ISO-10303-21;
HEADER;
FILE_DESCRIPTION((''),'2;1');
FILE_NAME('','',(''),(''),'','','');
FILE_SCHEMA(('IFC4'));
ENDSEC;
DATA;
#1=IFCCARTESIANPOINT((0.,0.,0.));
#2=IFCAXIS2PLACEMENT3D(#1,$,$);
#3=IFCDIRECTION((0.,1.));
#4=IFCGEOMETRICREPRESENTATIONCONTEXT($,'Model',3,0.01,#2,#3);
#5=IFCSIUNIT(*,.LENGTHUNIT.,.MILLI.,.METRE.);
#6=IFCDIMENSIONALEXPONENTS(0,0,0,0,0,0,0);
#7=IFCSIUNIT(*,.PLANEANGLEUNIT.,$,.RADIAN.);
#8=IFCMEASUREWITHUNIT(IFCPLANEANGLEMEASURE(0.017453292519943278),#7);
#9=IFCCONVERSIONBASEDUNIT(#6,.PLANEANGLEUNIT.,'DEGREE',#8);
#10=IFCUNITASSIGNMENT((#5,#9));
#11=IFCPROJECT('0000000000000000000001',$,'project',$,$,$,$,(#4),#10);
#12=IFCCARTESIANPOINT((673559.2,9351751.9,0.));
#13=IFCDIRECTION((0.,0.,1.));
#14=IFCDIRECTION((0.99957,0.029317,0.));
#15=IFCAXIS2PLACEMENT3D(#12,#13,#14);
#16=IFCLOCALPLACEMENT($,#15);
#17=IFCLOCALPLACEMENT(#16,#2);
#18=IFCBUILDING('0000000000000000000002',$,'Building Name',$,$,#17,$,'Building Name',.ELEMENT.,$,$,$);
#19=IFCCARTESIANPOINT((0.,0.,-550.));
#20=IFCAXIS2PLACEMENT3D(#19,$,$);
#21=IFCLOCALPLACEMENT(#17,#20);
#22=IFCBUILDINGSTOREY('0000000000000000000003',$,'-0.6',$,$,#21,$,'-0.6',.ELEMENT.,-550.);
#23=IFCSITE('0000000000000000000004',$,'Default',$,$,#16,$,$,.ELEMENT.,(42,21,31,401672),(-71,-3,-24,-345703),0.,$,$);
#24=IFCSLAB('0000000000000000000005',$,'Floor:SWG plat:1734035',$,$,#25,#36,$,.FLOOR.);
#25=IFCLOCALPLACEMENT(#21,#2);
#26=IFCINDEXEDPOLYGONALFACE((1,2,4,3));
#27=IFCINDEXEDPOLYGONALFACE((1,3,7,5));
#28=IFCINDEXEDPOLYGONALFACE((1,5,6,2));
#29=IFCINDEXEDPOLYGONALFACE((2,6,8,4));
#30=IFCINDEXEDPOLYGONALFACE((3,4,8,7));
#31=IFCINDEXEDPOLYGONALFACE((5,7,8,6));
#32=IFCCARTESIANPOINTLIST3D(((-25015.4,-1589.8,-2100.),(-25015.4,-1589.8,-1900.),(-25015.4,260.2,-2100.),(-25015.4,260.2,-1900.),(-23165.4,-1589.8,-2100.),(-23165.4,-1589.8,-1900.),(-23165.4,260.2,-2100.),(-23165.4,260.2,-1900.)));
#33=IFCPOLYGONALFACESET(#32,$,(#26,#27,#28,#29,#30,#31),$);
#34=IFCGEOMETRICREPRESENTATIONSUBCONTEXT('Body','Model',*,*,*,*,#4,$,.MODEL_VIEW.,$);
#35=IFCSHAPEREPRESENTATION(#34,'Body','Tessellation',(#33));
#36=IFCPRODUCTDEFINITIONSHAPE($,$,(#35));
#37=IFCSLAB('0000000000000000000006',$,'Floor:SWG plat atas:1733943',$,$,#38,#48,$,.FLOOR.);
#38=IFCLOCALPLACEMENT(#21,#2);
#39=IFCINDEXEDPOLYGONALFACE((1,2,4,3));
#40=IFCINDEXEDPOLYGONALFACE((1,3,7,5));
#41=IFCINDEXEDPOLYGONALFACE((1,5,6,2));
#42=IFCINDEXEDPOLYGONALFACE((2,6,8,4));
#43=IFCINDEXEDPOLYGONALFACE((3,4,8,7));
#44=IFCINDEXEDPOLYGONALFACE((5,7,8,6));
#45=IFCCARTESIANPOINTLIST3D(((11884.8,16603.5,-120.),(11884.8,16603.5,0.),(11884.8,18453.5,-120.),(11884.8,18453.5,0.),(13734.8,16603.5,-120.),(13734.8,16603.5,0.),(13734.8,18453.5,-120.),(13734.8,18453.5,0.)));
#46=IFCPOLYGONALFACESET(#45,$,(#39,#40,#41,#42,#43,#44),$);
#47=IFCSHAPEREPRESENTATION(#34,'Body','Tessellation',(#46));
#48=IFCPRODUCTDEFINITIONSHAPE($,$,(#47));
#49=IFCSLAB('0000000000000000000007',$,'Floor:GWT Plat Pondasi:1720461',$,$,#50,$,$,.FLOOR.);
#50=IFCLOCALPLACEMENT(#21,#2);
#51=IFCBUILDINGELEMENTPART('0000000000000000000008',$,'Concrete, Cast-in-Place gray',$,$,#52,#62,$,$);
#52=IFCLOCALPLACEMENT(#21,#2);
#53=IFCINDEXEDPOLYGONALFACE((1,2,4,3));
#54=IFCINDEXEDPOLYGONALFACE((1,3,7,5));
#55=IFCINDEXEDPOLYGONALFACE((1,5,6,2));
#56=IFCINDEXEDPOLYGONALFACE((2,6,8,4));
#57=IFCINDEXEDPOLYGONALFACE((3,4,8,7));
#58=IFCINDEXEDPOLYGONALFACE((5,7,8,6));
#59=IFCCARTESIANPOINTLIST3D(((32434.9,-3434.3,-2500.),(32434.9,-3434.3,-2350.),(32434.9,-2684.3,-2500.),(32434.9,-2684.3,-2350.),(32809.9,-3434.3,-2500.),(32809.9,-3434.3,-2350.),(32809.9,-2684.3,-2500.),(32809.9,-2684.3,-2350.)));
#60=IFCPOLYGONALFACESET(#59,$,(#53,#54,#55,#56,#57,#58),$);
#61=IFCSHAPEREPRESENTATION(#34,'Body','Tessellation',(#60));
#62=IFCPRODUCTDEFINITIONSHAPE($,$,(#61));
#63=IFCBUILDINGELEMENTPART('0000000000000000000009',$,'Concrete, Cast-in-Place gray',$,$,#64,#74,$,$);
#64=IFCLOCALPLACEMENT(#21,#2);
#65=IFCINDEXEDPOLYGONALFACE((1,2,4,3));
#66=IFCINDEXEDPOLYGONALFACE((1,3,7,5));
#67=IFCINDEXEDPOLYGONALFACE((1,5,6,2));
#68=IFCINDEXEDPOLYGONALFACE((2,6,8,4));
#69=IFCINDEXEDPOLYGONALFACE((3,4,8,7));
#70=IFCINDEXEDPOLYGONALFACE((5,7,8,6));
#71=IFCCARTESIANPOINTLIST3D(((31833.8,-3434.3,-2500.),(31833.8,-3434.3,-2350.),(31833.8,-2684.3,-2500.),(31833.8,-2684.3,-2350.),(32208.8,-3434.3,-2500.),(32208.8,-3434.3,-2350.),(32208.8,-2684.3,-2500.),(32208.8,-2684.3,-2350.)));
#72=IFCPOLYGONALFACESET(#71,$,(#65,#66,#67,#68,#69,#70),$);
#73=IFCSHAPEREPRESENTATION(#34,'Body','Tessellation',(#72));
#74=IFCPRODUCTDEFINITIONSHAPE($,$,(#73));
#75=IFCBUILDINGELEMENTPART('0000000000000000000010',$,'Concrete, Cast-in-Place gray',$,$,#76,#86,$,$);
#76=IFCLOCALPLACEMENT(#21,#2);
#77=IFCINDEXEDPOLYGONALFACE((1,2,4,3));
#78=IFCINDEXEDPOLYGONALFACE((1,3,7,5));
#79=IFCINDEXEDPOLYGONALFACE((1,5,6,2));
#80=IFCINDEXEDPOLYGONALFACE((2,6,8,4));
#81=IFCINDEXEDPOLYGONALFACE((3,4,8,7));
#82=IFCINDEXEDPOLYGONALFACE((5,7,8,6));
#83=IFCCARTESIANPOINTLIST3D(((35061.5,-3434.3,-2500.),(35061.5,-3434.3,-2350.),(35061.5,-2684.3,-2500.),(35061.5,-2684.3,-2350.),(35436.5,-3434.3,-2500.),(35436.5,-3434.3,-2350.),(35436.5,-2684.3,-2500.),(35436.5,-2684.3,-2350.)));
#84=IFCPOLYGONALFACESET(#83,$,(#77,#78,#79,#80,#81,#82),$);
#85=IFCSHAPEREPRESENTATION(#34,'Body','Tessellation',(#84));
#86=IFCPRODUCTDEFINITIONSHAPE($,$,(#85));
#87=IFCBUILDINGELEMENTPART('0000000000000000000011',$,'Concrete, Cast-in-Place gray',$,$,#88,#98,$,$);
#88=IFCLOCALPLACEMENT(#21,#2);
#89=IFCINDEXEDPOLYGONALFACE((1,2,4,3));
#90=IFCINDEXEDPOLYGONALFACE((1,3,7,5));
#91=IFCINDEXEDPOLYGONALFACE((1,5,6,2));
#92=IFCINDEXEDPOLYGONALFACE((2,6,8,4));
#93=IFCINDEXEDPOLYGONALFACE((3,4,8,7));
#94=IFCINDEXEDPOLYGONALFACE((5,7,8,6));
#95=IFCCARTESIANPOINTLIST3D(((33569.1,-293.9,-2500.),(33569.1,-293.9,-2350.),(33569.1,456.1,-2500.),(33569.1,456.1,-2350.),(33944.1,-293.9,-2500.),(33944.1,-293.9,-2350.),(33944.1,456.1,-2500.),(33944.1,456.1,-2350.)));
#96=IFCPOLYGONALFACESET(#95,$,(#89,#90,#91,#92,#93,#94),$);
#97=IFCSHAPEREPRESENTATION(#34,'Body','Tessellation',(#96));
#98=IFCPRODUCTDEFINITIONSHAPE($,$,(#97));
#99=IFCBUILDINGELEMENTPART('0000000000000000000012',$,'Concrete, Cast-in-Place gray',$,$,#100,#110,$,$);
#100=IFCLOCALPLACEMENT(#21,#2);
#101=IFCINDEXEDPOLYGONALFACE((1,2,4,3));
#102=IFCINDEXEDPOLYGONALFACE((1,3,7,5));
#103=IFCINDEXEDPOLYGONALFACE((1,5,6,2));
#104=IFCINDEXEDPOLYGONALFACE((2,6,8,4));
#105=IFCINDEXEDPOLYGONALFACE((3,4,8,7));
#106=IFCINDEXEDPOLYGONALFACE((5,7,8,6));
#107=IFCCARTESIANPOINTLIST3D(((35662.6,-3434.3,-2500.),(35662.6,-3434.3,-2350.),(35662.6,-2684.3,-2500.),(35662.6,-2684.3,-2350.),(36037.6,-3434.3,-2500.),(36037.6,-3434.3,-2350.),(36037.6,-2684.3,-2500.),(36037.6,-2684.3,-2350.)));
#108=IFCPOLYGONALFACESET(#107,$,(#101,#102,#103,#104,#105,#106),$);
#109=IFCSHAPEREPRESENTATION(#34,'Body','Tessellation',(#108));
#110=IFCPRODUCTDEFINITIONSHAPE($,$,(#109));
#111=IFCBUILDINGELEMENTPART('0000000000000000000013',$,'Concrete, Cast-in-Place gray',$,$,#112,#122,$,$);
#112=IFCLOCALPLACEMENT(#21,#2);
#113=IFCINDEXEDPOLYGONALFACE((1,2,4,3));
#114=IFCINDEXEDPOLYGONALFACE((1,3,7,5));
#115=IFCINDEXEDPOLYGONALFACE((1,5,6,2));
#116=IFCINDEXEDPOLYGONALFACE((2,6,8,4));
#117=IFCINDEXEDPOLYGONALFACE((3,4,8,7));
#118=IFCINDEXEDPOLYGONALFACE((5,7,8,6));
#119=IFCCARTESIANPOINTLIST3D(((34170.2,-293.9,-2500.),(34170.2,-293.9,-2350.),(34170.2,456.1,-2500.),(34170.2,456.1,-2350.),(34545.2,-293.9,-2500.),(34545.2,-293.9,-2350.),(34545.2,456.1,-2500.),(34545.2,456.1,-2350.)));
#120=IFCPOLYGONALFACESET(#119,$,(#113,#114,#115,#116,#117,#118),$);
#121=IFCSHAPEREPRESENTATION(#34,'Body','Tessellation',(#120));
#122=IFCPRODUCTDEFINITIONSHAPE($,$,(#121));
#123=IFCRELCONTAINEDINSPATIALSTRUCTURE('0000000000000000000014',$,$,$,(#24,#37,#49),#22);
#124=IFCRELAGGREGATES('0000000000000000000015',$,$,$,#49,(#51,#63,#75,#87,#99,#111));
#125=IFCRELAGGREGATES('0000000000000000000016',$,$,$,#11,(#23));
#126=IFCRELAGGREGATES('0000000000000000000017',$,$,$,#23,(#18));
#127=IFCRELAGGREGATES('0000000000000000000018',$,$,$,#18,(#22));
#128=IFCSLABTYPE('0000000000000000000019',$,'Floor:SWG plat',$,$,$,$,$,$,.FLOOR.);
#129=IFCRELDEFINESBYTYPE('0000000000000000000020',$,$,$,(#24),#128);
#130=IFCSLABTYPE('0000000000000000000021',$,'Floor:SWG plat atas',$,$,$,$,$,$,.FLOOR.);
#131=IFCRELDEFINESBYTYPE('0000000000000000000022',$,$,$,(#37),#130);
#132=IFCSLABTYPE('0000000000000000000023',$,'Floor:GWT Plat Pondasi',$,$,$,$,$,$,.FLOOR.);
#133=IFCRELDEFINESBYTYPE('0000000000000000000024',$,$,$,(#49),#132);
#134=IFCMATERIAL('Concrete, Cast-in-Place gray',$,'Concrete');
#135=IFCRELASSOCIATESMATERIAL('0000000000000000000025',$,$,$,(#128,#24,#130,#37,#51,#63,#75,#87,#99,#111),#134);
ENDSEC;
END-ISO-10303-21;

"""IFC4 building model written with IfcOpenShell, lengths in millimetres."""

from ifc_helpers import new_model, entity, si_unit, converted_unit, direction, frame, origin, place, context, subcontext, project, spatial, indexed_curve, outline, extrude, material, type_object, element, aggregate, save


model = new_model("IFC4")

# Units and contexts
model_context = context("Model", 3, precision=0.01, world=origin(), true_north=direction((0.0, 1.0)))
body_context = subcontext(model_context, "Body", "Model", "MODEL_VIEW")
ifc_project = project(units=[si_unit("LENGTHUNIT", "METRE", prefix="MILLI"), converted_unit("PLANEANGLEUNIT", "DEGREE", entity("IfcPlaneAngleMeasure", 0.017453292519943278), si_unit("PLANEANGLEUNIT", "RADIAN"), dimensions=[0, 0, 0, 0, 0, 0, 0])], contexts=[model_context])

# Site, building, storey
site_placement = place(None, frame((673559.2, 9351751.9, 0.0), z_axis=(0.0, 0.0, 1.0), x_axis=(0.99957, 0.029317, 0.0)))
site = spatial("IfcSite", under=ifc_project, at=site_placement, Name="Default", CompositionType="ELEMENT", RefLatitude=(42, 21, 31, 401672), RefLongitude=(-71, -3, -24, -345703), RefElevation=0.0)
building_placement = place(site_placement, origin())
building = spatial("IfcBuilding", under=site, at=building_placement, Name="Building Name", LongName="Building Name", CompositionType="ELEMENT")
storey_placement = place(building_placement, frame((0.0, 0.0, -550.0)))
storey = spatial("IfcBuildingStorey", under=building, at=storey_placement, Name="-0.6", LongName="-0.6", CompositionType="ELEMENT", Elevation=-550.0)

# Shared definitions
ifc_material = material(Name="Concrete, Cast-in-Place gray", Category="Concrete")

# Slabs
slab_type_1 = type_object("IfcSlabType", Name="Floor:SWG plat", PredefinedType="FLOOR", material=ifc_material)
slab_1_placement = place(storey_placement, origin())
element("IfcSlab", 1, at=slab_1_placement, inside=storey, type_object=slab_type_1, material=ifc_material, Name="Floor:SWG plat:1734035", PredefinedType="FLOOR", context=body_context, shape_type="SweptSolid", body=[
    extrude(outline(indexed_curve([(-925.0, -925.0), (925.0, -925.0), (925.0, 925.0), (-925.0, 925.0), (-925.0, -925.0)], self_intersect=False)), frame((-24090.4, -664.8, -1900.0), z_axis=(0.0, 0.0, -1.0), x_axis=(0.0, 1.0, 0.0)), (0.0, 0.0, 1.0), 200.0),
])
slab_type_2 = type_object("IfcSlabType", Name="Floor:SWG plat atas", PredefinedType="FLOOR", material=ifc_material)
slab_2_placement = place(storey_placement, origin())
element("IfcSlab", 2, at=slab_2_placement, inside=storey, type_object=slab_type_2, material=ifc_material, Name="Floor:SWG plat atas:1733943", PredefinedType="FLOOR", context=body_context, shape_type="SweptSolid", body=[
    extrude(outline(indexed_curve([(-925.0, -925.0), (925.0, -925.0), (925.0, 925.0), (-925.0, 925.0), (-925.0, -925.0)], self_intersect=False)), frame((12809.8, 17528.5, 0.0), z_axis=(0.0, 0.0, -1.0), x_axis=(0.0, 1.0, 0.0)), (0.0, 0.0, 1.0), 120.0),
])

# Slab, building element parts
slab_type_3 = type_object("IfcSlabType", Name="Floor:GWT Plat Pondasi", PredefinedType="FLOOR")
slab_3_placement = place(storey_placement, origin())
slab_3 = element("IfcSlab", 3, at=slab_3_placement, inside=storey, type_object=slab_type_3, Name="Floor:GWT Plat Pondasi:1720461", PredefinedType="FLOOR")
building_element_part_1_placement = place(slab_3_placement, origin())
building_element_part_1 = element("IfcBuildingElementPart", 4, at=building_element_part_1_placement, material=ifc_material, Name="Concrete, Cast-in-Place gray", context=body_context, shape_type="SweptSolid", body=[
    extrude(outline(indexed_curve([(-375.0, -187.5), (375.0, -187.5), (375.0, 187.5), (-375.0, 187.5), (-375.0, -187.5)], self_intersect=False)), frame((32622.4, -3059.3, -2500.0), z_axis=(0.0, 0.0, 1.0), x_axis=(0.0, -1.0, 0.0)), (0.0, 0.0, 1.0), 150.0),
])
building_element_part_2_placement = place(slab_3_placement, origin())
building_element_part_2 = element("IfcBuildingElementPart", 5, at=building_element_part_2_placement, material=ifc_material, Name="Concrete, Cast-in-Place gray", context=body_context, shape_type="SweptSolid", body=[
    extrude(outline(indexed_curve([(-375.0, -187.5), (375.0, -187.5), (375.0, 187.5), (-375.0, 187.5), (-375.0, -187.5)], self_intersect=False)), frame((32021.3, -3059.3, -2500.0), z_axis=(0.0, 0.0, 1.0), x_axis=(0.0, -1.0, 0.0)), (0.0, 0.0, 1.0), 150.0),
])
building_element_part_3_placement = place(slab_3_placement, origin())
building_element_part_3 = element("IfcBuildingElementPart", 6, at=building_element_part_3_placement, material=ifc_material, Name="Concrete, Cast-in-Place gray", context=body_context, shape_type="SweptSolid", body=[
    extrude(outline(indexed_curve([(-375.0, -187.5), (375.0, -187.5), (375.0, 187.5), (-375.0, 187.5), (-375.0, -187.5)], self_intersect=False)), frame((35249.0, -3059.3, -2500.0), z_axis=(0.0, 0.0, 1.0), x_axis=(0.0, -1.0, 0.0)), (0.0, 0.0, 1.0), 150.0),
])
building_element_part_4_placement = place(slab_3_placement, origin())
building_element_part_4 = element("IfcBuildingElementPart", 7, at=building_element_part_4_placement, material=ifc_material, Name="Concrete, Cast-in-Place gray", context=body_context, shape_type="SweptSolid", body=[
    extrude(outline(indexed_curve([(-375.0, -187.5), (375.0, -187.5), (375.0, 187.5), (-375.0, 187.5), (-375.0, -187.5)], self_intersect=False)), frame((33756.6, 81.1, -2500.0), z_axis=(0.0, 0.0, 1.0), x_axis=(0.0, -1.0, 0.0)), (0.0, 0.0, 1.0), 150.0),
])
building_element_part_5_placement = place(slab_3_placement, origin())
building_element_part_5 = element("IfcBuildingElementPart", 8, at=building_element_part_5_placement, material=ifc_material, Name="Concrete, Cast-in-Place gray", context=body_context, shape_type="SweptSolid", body=[
    extrude(outline(indexed_curve([(-375.0, -187.5), (375.0, -187.5), (375.0, 187.5), (-375.0, 187.5), (-375.0, -187.5)], self_intersect=False)), frame((35850.1, -3059.3, -2500.0), z_axis=(0.0, 0.0, 1.0), x_axis=(0.0, -1.0, 0.0)), (0.0, 0.0, 1.0), 150.0),
])
building_element_part_6_placement = place(slab_3_placement, origin())
building_element_part_6 = element("IfcBuildingElementPart", 9, at=building_element_part_6_placement, material=ifc_material, Name="Concrete, Cast-in-Place gray", context=body_context, shape_type="SweptSolid", body=[
    extrude(outline(indexed_curve([(-375.0, -187.5), (375.0, -187.5), (375.0, 187.5), (-375.0, 187.5), (-375.0, -187.5)], self_intersect=False)), frame((34357.7, 81.1, -2500.0), z_axis=(0.0, 0.0, 1.0), x_axis=(0.0, -1.0, 0.0)), (0.0, 0.0, 1.0), 150.0),
])
aggregate(slab_3, [building_element_part_1, building_element_part_2, building_element_part_3, building_element_part_4, building_element_part_5, building_element_part_6])

save(model, "model.ifc")
